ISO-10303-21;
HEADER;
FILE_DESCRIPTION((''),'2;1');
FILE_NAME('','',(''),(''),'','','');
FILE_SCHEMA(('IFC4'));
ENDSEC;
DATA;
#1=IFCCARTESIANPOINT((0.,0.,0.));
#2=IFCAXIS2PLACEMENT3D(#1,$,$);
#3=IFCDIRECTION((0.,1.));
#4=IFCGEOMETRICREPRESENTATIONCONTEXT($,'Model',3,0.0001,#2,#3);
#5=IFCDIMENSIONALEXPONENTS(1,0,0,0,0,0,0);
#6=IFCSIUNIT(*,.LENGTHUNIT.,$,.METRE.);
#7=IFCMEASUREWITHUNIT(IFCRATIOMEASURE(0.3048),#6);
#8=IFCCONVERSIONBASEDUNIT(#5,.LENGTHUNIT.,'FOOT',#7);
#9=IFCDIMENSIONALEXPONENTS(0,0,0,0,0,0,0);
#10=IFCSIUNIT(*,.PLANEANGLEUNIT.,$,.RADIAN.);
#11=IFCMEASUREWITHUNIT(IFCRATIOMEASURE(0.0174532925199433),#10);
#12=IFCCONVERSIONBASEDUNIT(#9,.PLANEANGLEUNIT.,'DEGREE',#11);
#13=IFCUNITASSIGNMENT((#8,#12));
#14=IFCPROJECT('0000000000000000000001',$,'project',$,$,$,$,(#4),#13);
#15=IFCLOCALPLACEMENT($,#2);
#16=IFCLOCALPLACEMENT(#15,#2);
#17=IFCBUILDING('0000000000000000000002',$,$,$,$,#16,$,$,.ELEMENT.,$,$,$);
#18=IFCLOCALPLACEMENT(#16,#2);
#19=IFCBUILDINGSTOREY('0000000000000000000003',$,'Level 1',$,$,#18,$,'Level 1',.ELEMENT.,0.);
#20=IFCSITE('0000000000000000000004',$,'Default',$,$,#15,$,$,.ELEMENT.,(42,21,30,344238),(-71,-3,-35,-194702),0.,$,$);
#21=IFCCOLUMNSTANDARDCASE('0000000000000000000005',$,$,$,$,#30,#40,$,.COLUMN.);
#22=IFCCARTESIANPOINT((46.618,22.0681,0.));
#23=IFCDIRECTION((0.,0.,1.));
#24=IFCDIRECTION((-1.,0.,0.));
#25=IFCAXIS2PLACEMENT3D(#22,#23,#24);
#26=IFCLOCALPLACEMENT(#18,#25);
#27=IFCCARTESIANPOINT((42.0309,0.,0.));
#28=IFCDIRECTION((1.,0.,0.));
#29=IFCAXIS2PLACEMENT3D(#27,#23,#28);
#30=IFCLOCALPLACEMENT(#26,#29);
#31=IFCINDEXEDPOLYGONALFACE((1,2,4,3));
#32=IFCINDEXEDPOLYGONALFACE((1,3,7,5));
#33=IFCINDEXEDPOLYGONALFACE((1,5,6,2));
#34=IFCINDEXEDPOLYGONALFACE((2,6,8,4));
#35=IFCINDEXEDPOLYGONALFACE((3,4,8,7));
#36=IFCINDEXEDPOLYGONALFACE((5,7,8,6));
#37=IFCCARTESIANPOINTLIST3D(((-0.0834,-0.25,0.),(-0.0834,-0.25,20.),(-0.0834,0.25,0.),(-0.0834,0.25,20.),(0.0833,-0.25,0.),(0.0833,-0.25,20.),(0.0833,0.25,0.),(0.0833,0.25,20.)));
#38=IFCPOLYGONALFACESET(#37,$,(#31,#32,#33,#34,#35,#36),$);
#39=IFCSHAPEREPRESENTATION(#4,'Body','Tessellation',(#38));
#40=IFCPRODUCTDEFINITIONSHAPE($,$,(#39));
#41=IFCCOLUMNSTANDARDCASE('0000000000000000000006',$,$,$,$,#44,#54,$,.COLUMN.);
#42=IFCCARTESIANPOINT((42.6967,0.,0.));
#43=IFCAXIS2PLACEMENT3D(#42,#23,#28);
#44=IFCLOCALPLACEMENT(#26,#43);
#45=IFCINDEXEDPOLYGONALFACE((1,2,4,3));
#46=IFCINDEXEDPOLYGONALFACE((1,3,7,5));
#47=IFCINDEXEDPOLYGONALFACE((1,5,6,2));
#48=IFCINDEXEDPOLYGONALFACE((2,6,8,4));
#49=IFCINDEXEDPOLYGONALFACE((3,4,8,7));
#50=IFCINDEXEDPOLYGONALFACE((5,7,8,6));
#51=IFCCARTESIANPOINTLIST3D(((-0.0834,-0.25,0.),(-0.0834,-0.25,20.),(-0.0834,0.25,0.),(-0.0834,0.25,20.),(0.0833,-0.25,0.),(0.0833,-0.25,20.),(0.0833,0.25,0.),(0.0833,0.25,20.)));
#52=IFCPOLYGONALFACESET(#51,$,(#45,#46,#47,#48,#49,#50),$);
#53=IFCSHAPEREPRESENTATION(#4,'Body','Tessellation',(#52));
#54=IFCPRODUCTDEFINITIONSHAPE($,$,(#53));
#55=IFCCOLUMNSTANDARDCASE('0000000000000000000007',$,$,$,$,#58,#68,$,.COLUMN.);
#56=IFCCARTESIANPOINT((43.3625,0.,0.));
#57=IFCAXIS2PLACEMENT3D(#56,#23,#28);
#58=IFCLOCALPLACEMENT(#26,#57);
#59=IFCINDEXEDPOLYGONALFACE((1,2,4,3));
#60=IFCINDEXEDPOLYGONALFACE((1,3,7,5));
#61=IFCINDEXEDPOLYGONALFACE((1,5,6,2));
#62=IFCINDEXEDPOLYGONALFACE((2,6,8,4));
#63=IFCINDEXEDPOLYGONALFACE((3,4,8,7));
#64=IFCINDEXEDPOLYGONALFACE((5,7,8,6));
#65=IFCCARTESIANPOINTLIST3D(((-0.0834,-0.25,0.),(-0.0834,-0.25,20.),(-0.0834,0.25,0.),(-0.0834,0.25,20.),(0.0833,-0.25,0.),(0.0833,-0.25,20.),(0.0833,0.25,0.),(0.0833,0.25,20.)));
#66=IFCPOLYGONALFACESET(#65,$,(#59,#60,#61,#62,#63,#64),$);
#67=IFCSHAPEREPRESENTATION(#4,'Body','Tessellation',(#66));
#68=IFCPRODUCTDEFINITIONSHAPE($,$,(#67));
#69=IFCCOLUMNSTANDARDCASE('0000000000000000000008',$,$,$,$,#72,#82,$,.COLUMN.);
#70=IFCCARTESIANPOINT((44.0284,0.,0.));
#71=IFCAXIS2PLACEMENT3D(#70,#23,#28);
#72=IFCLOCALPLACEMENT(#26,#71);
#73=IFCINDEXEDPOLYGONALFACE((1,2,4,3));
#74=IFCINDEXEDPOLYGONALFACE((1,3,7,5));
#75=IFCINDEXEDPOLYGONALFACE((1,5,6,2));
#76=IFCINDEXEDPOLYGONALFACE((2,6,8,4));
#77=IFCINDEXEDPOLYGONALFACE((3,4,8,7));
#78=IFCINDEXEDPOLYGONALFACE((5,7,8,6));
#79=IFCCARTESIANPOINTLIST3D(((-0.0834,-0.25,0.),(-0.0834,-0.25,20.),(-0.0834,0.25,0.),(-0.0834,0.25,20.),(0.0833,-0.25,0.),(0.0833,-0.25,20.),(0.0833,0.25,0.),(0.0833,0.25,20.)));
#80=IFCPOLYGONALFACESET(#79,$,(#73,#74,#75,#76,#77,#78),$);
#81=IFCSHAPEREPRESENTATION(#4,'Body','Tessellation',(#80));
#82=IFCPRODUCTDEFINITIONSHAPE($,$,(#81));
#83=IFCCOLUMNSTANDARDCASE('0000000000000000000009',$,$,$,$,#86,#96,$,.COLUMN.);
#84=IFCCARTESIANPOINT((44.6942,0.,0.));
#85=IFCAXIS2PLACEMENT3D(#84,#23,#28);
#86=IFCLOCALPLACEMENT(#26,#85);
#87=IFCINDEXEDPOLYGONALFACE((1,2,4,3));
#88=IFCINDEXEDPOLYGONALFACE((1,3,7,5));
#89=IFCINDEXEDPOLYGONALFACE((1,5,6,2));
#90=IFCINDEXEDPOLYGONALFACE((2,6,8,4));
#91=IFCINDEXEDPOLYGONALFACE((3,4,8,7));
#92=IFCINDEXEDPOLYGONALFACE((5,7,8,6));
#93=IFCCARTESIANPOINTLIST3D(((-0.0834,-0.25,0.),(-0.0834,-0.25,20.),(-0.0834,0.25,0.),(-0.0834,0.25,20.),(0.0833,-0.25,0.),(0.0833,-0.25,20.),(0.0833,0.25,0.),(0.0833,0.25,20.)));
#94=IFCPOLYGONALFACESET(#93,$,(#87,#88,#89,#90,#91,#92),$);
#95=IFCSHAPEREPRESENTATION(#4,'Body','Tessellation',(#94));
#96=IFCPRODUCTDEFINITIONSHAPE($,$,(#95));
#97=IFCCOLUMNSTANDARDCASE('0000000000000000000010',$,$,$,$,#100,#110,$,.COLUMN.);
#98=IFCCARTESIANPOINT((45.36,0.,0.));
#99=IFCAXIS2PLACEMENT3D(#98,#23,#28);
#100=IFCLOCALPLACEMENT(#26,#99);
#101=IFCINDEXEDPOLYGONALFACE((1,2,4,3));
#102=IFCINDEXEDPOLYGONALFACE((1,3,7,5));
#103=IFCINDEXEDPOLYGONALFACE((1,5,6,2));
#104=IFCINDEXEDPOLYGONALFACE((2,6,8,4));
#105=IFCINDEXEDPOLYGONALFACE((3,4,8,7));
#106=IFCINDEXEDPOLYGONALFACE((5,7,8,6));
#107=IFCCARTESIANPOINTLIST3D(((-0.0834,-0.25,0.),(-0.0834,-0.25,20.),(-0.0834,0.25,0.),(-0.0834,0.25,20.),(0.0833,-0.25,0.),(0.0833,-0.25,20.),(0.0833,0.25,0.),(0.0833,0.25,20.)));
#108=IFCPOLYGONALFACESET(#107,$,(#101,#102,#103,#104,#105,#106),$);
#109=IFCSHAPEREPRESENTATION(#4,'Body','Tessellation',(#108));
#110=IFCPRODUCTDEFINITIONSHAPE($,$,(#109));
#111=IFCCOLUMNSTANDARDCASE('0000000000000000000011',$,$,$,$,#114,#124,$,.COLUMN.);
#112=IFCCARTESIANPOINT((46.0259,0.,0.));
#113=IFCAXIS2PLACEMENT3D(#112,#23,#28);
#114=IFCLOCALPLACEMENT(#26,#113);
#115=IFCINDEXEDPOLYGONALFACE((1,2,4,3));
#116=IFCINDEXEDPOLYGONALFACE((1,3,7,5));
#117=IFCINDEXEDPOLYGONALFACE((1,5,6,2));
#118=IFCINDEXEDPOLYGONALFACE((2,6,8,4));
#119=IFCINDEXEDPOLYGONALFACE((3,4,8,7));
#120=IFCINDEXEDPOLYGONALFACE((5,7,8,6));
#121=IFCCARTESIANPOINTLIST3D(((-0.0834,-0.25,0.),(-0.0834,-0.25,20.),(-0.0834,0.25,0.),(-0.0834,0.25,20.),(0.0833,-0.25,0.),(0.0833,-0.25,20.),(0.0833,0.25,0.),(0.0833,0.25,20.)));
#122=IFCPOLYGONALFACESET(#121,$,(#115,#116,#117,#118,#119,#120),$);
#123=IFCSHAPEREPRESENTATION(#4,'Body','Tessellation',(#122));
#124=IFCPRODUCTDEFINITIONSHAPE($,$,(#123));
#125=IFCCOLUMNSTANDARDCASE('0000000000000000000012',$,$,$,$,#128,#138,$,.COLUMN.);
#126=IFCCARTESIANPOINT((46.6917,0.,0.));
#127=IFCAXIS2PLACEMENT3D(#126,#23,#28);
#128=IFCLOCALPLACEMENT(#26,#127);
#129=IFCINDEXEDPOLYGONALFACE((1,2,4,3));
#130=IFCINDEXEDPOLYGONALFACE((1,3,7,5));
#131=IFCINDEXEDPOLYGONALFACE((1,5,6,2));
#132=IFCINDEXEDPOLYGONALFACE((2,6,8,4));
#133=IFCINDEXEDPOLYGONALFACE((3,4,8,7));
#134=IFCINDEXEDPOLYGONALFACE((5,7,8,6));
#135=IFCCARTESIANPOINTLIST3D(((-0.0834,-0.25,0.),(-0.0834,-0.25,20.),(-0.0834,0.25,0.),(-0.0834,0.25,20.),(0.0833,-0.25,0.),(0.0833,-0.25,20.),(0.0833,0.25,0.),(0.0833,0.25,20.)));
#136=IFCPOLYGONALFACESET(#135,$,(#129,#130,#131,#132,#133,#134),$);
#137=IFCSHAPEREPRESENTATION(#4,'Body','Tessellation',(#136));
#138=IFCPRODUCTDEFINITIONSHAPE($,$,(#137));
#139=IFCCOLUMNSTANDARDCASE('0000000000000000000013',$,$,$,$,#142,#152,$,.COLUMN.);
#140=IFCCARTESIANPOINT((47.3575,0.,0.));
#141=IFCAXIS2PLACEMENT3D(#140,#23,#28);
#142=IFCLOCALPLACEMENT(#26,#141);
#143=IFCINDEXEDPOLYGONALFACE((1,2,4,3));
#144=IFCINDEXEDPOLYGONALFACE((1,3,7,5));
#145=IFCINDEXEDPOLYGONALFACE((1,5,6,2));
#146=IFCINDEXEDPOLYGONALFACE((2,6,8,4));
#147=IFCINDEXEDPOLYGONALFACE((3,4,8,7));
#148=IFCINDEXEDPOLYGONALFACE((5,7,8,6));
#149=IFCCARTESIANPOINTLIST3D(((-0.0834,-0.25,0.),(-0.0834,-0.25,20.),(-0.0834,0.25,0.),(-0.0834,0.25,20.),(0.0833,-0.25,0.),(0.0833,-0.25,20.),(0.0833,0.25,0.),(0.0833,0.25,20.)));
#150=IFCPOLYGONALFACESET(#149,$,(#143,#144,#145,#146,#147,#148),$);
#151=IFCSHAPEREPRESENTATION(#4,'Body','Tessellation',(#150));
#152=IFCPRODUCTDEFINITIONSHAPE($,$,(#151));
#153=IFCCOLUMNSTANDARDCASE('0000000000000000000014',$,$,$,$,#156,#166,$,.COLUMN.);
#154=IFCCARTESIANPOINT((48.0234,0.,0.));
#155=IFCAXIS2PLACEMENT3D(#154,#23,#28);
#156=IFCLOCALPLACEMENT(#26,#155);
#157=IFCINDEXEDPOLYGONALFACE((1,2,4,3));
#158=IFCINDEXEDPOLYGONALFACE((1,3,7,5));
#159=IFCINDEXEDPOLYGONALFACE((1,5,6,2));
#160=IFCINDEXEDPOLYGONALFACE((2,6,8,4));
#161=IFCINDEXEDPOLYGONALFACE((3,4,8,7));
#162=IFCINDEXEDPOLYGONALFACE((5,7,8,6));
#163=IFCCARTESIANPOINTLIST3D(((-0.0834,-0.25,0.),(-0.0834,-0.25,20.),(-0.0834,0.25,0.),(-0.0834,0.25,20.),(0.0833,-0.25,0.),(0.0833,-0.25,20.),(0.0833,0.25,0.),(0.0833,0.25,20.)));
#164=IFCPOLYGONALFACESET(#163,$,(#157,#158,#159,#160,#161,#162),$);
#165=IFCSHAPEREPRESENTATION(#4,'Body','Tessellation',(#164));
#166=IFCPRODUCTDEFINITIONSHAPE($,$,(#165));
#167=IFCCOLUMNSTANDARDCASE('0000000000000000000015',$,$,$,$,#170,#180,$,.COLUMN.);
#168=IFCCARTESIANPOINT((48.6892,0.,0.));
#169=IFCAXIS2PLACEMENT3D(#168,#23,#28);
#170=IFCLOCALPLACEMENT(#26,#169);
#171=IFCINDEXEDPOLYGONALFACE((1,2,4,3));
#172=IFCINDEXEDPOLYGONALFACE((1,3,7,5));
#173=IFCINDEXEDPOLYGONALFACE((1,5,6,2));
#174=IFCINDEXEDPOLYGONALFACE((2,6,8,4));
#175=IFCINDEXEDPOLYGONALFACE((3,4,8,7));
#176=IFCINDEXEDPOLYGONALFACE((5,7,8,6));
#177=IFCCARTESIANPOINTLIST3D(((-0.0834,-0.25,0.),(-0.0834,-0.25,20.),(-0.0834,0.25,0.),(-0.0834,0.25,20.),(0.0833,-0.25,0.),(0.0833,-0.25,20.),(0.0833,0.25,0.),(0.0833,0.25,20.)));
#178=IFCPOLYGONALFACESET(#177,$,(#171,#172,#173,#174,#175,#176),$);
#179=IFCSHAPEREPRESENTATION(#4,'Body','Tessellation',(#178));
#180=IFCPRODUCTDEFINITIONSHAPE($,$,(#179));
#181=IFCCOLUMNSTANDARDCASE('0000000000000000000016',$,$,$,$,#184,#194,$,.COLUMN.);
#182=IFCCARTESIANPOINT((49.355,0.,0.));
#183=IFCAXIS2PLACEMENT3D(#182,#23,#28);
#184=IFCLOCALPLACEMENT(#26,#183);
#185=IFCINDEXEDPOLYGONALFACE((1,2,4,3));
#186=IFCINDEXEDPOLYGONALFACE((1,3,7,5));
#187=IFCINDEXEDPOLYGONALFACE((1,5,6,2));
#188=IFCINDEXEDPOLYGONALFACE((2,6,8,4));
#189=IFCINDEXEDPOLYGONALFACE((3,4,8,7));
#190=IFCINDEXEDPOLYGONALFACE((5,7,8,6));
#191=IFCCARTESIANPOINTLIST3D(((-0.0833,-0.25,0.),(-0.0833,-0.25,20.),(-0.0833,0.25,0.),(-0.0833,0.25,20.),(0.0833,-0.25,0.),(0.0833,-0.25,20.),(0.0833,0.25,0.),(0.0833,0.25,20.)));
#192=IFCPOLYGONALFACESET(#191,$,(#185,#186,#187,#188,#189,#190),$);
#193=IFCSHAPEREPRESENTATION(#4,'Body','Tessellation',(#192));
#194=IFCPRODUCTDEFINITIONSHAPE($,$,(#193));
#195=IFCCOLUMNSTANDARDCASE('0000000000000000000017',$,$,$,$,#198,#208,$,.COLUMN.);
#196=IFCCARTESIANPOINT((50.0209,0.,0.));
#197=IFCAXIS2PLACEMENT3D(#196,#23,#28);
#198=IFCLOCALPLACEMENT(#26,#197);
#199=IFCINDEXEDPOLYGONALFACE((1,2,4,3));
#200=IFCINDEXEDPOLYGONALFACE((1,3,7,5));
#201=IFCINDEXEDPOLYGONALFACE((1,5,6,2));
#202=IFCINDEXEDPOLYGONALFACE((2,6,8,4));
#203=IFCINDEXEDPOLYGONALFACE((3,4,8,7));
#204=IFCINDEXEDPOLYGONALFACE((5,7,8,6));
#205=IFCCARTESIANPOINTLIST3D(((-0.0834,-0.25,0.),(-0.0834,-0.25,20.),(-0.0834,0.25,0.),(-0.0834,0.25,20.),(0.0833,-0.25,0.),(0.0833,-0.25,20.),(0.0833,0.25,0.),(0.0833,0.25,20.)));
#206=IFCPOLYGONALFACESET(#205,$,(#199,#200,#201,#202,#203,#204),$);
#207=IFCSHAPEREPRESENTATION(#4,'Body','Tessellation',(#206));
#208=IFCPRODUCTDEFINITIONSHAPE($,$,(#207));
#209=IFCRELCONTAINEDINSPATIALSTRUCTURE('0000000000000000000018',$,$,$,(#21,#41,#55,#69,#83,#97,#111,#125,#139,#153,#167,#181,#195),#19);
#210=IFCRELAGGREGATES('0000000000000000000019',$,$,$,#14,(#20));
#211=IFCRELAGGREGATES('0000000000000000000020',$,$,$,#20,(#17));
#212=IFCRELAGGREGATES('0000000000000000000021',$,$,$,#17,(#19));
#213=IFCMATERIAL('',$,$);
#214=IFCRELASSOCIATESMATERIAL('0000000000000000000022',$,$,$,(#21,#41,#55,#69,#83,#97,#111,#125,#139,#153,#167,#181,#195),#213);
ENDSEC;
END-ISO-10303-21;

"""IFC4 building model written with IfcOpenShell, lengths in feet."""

from ifc_helpers import new_model, entity, si_unit, converted_unit, direction, frame, origin, place, context, project, spatial, rectangle, extrude, material, element, save


model = new_model("IFC4")

# Units and contexts
model_context = context("Model", 3, precision=0.0001, world=origin(), true_north=direction((0.0, 1.0)))
ifc_project = project(units=[converted_unit("LENGTHUNIT", "FOOT", entity("IfcRatioMeasure", 0.3048), si_unit("LENGTHUNIT", "METRE"), dimensions=[1, 0, 0, 0, 0, 0, 0]), converted_unit("PLANEANGLEUNIT", "DEGREE", entity("IfcRatioMeasure", 0.0174532925199433), si_unit("PLANEANGLEUNIT", "RADIAN"), dimensions=[0, 0, 0, 0, 0, 0, 0])], contexts=[model_context])

# Site, building, storey
site_placement = place(None, origin())
site = spatial("IfcSite", under=ifc_project, at=site_placement, Name="Default", CompositionType="ELEMENT", RefLatitude=(42, 21, 30, 344238), RefLongitude=(-71, -3, -35, -194702), RefElevation=0.0)
building_placement = place(site_placement, origin())
building = spatial("IfcBuilding", under=site, at=building_placement, CompositionType="ELEMENT")
storey_placement = place(building_placement, origin())
storey = spatial("IfcBuildingStorey", under=building, at=storey_placement, Name="Level 1", LongName="Level 1", CompositionType="ELEMENT", Elevation=0.0)

# Columns
ifc_material = material(Name="")
placement = place(storey_placement, frame((46.618, 22.0681, 0.0), z_axis=(0.0, 0.0, 1.0), x_axis=(-1.0, 0.0, 0.0)))
for number, where, z_axis, x_axis in (
    (1, (42.0309, 0.0, 0.0), (0.0, 0.0, 1.0), (1.0, 0.0, 0.0)),
    (2, (42.6967, 0.0, 0.0), (0.0, 0.0, 1.0), (1.0, 0.0, 0.0)),
    (3, (43.3625, 0.0, 0.0), (0.0, 0.0, 1.0), (1.0, 0.0, 0.0)),
    (4, (44.0284, 0.0, 0.0), (0.0, 0.0, 1.0), (1.0, 0.0, 0.0)),
    (5, (44.6942, 0.0, 0.0), (0.0, 0.0, 1.0), (1.0, 0.0, 0.0)),
    (6, (45.36, 0.0, 0.0), (0.0, 0.0, 1.0), (1.0, 0.0, 0.0)),
    (7, (46.0259, 0.0, 0.0), (0.0, 0.0, 1.0), (1.0, 0.0, 0.0)),
    (8, (46.6917, 0.0, 0.0), (0.0, 0.0, 1.0), (1.0, 0.0, 0.0)),
    (9, (47.3575, 0.0, 0.0), (0.0, 0.0, 1.0), (1.0, 0.0, 0.0)),
    (10, (48.0234, 0.0, 0.0), (0.0, 0.0, 1.0), (1.0, 0.0, 0.0)),
    (11, (48.6892, 0.0, 0.0), (0.0, 0.0, 1.0), (1.0, 0.0, 0.0)),
    (12, (49.355, 0.0, 0.0), (0.0, 0.0, 1.0), (1.0, 0.0, 0.0)),
    (13, (50.0209, 0.0, 0.0), (0.0, 0.0, 1.0), (1.0, 0.0, 0.0)),
):
    element("IfcColumnStandardCase", number, at=place(placement, frame(where, z_axis=z_axis, x_axis=x_axis)), inside=storey, material=ifc_material, PredefinedType="COLUMN", context=model_context, shape_type="SweptSolid", body=[
        extrude(rectangle(XDim=0.1667, YDim=0.5), origin(), (0.0, 0.0, 1.0), 20.0),
    ])

save(model, "model.ifc")
